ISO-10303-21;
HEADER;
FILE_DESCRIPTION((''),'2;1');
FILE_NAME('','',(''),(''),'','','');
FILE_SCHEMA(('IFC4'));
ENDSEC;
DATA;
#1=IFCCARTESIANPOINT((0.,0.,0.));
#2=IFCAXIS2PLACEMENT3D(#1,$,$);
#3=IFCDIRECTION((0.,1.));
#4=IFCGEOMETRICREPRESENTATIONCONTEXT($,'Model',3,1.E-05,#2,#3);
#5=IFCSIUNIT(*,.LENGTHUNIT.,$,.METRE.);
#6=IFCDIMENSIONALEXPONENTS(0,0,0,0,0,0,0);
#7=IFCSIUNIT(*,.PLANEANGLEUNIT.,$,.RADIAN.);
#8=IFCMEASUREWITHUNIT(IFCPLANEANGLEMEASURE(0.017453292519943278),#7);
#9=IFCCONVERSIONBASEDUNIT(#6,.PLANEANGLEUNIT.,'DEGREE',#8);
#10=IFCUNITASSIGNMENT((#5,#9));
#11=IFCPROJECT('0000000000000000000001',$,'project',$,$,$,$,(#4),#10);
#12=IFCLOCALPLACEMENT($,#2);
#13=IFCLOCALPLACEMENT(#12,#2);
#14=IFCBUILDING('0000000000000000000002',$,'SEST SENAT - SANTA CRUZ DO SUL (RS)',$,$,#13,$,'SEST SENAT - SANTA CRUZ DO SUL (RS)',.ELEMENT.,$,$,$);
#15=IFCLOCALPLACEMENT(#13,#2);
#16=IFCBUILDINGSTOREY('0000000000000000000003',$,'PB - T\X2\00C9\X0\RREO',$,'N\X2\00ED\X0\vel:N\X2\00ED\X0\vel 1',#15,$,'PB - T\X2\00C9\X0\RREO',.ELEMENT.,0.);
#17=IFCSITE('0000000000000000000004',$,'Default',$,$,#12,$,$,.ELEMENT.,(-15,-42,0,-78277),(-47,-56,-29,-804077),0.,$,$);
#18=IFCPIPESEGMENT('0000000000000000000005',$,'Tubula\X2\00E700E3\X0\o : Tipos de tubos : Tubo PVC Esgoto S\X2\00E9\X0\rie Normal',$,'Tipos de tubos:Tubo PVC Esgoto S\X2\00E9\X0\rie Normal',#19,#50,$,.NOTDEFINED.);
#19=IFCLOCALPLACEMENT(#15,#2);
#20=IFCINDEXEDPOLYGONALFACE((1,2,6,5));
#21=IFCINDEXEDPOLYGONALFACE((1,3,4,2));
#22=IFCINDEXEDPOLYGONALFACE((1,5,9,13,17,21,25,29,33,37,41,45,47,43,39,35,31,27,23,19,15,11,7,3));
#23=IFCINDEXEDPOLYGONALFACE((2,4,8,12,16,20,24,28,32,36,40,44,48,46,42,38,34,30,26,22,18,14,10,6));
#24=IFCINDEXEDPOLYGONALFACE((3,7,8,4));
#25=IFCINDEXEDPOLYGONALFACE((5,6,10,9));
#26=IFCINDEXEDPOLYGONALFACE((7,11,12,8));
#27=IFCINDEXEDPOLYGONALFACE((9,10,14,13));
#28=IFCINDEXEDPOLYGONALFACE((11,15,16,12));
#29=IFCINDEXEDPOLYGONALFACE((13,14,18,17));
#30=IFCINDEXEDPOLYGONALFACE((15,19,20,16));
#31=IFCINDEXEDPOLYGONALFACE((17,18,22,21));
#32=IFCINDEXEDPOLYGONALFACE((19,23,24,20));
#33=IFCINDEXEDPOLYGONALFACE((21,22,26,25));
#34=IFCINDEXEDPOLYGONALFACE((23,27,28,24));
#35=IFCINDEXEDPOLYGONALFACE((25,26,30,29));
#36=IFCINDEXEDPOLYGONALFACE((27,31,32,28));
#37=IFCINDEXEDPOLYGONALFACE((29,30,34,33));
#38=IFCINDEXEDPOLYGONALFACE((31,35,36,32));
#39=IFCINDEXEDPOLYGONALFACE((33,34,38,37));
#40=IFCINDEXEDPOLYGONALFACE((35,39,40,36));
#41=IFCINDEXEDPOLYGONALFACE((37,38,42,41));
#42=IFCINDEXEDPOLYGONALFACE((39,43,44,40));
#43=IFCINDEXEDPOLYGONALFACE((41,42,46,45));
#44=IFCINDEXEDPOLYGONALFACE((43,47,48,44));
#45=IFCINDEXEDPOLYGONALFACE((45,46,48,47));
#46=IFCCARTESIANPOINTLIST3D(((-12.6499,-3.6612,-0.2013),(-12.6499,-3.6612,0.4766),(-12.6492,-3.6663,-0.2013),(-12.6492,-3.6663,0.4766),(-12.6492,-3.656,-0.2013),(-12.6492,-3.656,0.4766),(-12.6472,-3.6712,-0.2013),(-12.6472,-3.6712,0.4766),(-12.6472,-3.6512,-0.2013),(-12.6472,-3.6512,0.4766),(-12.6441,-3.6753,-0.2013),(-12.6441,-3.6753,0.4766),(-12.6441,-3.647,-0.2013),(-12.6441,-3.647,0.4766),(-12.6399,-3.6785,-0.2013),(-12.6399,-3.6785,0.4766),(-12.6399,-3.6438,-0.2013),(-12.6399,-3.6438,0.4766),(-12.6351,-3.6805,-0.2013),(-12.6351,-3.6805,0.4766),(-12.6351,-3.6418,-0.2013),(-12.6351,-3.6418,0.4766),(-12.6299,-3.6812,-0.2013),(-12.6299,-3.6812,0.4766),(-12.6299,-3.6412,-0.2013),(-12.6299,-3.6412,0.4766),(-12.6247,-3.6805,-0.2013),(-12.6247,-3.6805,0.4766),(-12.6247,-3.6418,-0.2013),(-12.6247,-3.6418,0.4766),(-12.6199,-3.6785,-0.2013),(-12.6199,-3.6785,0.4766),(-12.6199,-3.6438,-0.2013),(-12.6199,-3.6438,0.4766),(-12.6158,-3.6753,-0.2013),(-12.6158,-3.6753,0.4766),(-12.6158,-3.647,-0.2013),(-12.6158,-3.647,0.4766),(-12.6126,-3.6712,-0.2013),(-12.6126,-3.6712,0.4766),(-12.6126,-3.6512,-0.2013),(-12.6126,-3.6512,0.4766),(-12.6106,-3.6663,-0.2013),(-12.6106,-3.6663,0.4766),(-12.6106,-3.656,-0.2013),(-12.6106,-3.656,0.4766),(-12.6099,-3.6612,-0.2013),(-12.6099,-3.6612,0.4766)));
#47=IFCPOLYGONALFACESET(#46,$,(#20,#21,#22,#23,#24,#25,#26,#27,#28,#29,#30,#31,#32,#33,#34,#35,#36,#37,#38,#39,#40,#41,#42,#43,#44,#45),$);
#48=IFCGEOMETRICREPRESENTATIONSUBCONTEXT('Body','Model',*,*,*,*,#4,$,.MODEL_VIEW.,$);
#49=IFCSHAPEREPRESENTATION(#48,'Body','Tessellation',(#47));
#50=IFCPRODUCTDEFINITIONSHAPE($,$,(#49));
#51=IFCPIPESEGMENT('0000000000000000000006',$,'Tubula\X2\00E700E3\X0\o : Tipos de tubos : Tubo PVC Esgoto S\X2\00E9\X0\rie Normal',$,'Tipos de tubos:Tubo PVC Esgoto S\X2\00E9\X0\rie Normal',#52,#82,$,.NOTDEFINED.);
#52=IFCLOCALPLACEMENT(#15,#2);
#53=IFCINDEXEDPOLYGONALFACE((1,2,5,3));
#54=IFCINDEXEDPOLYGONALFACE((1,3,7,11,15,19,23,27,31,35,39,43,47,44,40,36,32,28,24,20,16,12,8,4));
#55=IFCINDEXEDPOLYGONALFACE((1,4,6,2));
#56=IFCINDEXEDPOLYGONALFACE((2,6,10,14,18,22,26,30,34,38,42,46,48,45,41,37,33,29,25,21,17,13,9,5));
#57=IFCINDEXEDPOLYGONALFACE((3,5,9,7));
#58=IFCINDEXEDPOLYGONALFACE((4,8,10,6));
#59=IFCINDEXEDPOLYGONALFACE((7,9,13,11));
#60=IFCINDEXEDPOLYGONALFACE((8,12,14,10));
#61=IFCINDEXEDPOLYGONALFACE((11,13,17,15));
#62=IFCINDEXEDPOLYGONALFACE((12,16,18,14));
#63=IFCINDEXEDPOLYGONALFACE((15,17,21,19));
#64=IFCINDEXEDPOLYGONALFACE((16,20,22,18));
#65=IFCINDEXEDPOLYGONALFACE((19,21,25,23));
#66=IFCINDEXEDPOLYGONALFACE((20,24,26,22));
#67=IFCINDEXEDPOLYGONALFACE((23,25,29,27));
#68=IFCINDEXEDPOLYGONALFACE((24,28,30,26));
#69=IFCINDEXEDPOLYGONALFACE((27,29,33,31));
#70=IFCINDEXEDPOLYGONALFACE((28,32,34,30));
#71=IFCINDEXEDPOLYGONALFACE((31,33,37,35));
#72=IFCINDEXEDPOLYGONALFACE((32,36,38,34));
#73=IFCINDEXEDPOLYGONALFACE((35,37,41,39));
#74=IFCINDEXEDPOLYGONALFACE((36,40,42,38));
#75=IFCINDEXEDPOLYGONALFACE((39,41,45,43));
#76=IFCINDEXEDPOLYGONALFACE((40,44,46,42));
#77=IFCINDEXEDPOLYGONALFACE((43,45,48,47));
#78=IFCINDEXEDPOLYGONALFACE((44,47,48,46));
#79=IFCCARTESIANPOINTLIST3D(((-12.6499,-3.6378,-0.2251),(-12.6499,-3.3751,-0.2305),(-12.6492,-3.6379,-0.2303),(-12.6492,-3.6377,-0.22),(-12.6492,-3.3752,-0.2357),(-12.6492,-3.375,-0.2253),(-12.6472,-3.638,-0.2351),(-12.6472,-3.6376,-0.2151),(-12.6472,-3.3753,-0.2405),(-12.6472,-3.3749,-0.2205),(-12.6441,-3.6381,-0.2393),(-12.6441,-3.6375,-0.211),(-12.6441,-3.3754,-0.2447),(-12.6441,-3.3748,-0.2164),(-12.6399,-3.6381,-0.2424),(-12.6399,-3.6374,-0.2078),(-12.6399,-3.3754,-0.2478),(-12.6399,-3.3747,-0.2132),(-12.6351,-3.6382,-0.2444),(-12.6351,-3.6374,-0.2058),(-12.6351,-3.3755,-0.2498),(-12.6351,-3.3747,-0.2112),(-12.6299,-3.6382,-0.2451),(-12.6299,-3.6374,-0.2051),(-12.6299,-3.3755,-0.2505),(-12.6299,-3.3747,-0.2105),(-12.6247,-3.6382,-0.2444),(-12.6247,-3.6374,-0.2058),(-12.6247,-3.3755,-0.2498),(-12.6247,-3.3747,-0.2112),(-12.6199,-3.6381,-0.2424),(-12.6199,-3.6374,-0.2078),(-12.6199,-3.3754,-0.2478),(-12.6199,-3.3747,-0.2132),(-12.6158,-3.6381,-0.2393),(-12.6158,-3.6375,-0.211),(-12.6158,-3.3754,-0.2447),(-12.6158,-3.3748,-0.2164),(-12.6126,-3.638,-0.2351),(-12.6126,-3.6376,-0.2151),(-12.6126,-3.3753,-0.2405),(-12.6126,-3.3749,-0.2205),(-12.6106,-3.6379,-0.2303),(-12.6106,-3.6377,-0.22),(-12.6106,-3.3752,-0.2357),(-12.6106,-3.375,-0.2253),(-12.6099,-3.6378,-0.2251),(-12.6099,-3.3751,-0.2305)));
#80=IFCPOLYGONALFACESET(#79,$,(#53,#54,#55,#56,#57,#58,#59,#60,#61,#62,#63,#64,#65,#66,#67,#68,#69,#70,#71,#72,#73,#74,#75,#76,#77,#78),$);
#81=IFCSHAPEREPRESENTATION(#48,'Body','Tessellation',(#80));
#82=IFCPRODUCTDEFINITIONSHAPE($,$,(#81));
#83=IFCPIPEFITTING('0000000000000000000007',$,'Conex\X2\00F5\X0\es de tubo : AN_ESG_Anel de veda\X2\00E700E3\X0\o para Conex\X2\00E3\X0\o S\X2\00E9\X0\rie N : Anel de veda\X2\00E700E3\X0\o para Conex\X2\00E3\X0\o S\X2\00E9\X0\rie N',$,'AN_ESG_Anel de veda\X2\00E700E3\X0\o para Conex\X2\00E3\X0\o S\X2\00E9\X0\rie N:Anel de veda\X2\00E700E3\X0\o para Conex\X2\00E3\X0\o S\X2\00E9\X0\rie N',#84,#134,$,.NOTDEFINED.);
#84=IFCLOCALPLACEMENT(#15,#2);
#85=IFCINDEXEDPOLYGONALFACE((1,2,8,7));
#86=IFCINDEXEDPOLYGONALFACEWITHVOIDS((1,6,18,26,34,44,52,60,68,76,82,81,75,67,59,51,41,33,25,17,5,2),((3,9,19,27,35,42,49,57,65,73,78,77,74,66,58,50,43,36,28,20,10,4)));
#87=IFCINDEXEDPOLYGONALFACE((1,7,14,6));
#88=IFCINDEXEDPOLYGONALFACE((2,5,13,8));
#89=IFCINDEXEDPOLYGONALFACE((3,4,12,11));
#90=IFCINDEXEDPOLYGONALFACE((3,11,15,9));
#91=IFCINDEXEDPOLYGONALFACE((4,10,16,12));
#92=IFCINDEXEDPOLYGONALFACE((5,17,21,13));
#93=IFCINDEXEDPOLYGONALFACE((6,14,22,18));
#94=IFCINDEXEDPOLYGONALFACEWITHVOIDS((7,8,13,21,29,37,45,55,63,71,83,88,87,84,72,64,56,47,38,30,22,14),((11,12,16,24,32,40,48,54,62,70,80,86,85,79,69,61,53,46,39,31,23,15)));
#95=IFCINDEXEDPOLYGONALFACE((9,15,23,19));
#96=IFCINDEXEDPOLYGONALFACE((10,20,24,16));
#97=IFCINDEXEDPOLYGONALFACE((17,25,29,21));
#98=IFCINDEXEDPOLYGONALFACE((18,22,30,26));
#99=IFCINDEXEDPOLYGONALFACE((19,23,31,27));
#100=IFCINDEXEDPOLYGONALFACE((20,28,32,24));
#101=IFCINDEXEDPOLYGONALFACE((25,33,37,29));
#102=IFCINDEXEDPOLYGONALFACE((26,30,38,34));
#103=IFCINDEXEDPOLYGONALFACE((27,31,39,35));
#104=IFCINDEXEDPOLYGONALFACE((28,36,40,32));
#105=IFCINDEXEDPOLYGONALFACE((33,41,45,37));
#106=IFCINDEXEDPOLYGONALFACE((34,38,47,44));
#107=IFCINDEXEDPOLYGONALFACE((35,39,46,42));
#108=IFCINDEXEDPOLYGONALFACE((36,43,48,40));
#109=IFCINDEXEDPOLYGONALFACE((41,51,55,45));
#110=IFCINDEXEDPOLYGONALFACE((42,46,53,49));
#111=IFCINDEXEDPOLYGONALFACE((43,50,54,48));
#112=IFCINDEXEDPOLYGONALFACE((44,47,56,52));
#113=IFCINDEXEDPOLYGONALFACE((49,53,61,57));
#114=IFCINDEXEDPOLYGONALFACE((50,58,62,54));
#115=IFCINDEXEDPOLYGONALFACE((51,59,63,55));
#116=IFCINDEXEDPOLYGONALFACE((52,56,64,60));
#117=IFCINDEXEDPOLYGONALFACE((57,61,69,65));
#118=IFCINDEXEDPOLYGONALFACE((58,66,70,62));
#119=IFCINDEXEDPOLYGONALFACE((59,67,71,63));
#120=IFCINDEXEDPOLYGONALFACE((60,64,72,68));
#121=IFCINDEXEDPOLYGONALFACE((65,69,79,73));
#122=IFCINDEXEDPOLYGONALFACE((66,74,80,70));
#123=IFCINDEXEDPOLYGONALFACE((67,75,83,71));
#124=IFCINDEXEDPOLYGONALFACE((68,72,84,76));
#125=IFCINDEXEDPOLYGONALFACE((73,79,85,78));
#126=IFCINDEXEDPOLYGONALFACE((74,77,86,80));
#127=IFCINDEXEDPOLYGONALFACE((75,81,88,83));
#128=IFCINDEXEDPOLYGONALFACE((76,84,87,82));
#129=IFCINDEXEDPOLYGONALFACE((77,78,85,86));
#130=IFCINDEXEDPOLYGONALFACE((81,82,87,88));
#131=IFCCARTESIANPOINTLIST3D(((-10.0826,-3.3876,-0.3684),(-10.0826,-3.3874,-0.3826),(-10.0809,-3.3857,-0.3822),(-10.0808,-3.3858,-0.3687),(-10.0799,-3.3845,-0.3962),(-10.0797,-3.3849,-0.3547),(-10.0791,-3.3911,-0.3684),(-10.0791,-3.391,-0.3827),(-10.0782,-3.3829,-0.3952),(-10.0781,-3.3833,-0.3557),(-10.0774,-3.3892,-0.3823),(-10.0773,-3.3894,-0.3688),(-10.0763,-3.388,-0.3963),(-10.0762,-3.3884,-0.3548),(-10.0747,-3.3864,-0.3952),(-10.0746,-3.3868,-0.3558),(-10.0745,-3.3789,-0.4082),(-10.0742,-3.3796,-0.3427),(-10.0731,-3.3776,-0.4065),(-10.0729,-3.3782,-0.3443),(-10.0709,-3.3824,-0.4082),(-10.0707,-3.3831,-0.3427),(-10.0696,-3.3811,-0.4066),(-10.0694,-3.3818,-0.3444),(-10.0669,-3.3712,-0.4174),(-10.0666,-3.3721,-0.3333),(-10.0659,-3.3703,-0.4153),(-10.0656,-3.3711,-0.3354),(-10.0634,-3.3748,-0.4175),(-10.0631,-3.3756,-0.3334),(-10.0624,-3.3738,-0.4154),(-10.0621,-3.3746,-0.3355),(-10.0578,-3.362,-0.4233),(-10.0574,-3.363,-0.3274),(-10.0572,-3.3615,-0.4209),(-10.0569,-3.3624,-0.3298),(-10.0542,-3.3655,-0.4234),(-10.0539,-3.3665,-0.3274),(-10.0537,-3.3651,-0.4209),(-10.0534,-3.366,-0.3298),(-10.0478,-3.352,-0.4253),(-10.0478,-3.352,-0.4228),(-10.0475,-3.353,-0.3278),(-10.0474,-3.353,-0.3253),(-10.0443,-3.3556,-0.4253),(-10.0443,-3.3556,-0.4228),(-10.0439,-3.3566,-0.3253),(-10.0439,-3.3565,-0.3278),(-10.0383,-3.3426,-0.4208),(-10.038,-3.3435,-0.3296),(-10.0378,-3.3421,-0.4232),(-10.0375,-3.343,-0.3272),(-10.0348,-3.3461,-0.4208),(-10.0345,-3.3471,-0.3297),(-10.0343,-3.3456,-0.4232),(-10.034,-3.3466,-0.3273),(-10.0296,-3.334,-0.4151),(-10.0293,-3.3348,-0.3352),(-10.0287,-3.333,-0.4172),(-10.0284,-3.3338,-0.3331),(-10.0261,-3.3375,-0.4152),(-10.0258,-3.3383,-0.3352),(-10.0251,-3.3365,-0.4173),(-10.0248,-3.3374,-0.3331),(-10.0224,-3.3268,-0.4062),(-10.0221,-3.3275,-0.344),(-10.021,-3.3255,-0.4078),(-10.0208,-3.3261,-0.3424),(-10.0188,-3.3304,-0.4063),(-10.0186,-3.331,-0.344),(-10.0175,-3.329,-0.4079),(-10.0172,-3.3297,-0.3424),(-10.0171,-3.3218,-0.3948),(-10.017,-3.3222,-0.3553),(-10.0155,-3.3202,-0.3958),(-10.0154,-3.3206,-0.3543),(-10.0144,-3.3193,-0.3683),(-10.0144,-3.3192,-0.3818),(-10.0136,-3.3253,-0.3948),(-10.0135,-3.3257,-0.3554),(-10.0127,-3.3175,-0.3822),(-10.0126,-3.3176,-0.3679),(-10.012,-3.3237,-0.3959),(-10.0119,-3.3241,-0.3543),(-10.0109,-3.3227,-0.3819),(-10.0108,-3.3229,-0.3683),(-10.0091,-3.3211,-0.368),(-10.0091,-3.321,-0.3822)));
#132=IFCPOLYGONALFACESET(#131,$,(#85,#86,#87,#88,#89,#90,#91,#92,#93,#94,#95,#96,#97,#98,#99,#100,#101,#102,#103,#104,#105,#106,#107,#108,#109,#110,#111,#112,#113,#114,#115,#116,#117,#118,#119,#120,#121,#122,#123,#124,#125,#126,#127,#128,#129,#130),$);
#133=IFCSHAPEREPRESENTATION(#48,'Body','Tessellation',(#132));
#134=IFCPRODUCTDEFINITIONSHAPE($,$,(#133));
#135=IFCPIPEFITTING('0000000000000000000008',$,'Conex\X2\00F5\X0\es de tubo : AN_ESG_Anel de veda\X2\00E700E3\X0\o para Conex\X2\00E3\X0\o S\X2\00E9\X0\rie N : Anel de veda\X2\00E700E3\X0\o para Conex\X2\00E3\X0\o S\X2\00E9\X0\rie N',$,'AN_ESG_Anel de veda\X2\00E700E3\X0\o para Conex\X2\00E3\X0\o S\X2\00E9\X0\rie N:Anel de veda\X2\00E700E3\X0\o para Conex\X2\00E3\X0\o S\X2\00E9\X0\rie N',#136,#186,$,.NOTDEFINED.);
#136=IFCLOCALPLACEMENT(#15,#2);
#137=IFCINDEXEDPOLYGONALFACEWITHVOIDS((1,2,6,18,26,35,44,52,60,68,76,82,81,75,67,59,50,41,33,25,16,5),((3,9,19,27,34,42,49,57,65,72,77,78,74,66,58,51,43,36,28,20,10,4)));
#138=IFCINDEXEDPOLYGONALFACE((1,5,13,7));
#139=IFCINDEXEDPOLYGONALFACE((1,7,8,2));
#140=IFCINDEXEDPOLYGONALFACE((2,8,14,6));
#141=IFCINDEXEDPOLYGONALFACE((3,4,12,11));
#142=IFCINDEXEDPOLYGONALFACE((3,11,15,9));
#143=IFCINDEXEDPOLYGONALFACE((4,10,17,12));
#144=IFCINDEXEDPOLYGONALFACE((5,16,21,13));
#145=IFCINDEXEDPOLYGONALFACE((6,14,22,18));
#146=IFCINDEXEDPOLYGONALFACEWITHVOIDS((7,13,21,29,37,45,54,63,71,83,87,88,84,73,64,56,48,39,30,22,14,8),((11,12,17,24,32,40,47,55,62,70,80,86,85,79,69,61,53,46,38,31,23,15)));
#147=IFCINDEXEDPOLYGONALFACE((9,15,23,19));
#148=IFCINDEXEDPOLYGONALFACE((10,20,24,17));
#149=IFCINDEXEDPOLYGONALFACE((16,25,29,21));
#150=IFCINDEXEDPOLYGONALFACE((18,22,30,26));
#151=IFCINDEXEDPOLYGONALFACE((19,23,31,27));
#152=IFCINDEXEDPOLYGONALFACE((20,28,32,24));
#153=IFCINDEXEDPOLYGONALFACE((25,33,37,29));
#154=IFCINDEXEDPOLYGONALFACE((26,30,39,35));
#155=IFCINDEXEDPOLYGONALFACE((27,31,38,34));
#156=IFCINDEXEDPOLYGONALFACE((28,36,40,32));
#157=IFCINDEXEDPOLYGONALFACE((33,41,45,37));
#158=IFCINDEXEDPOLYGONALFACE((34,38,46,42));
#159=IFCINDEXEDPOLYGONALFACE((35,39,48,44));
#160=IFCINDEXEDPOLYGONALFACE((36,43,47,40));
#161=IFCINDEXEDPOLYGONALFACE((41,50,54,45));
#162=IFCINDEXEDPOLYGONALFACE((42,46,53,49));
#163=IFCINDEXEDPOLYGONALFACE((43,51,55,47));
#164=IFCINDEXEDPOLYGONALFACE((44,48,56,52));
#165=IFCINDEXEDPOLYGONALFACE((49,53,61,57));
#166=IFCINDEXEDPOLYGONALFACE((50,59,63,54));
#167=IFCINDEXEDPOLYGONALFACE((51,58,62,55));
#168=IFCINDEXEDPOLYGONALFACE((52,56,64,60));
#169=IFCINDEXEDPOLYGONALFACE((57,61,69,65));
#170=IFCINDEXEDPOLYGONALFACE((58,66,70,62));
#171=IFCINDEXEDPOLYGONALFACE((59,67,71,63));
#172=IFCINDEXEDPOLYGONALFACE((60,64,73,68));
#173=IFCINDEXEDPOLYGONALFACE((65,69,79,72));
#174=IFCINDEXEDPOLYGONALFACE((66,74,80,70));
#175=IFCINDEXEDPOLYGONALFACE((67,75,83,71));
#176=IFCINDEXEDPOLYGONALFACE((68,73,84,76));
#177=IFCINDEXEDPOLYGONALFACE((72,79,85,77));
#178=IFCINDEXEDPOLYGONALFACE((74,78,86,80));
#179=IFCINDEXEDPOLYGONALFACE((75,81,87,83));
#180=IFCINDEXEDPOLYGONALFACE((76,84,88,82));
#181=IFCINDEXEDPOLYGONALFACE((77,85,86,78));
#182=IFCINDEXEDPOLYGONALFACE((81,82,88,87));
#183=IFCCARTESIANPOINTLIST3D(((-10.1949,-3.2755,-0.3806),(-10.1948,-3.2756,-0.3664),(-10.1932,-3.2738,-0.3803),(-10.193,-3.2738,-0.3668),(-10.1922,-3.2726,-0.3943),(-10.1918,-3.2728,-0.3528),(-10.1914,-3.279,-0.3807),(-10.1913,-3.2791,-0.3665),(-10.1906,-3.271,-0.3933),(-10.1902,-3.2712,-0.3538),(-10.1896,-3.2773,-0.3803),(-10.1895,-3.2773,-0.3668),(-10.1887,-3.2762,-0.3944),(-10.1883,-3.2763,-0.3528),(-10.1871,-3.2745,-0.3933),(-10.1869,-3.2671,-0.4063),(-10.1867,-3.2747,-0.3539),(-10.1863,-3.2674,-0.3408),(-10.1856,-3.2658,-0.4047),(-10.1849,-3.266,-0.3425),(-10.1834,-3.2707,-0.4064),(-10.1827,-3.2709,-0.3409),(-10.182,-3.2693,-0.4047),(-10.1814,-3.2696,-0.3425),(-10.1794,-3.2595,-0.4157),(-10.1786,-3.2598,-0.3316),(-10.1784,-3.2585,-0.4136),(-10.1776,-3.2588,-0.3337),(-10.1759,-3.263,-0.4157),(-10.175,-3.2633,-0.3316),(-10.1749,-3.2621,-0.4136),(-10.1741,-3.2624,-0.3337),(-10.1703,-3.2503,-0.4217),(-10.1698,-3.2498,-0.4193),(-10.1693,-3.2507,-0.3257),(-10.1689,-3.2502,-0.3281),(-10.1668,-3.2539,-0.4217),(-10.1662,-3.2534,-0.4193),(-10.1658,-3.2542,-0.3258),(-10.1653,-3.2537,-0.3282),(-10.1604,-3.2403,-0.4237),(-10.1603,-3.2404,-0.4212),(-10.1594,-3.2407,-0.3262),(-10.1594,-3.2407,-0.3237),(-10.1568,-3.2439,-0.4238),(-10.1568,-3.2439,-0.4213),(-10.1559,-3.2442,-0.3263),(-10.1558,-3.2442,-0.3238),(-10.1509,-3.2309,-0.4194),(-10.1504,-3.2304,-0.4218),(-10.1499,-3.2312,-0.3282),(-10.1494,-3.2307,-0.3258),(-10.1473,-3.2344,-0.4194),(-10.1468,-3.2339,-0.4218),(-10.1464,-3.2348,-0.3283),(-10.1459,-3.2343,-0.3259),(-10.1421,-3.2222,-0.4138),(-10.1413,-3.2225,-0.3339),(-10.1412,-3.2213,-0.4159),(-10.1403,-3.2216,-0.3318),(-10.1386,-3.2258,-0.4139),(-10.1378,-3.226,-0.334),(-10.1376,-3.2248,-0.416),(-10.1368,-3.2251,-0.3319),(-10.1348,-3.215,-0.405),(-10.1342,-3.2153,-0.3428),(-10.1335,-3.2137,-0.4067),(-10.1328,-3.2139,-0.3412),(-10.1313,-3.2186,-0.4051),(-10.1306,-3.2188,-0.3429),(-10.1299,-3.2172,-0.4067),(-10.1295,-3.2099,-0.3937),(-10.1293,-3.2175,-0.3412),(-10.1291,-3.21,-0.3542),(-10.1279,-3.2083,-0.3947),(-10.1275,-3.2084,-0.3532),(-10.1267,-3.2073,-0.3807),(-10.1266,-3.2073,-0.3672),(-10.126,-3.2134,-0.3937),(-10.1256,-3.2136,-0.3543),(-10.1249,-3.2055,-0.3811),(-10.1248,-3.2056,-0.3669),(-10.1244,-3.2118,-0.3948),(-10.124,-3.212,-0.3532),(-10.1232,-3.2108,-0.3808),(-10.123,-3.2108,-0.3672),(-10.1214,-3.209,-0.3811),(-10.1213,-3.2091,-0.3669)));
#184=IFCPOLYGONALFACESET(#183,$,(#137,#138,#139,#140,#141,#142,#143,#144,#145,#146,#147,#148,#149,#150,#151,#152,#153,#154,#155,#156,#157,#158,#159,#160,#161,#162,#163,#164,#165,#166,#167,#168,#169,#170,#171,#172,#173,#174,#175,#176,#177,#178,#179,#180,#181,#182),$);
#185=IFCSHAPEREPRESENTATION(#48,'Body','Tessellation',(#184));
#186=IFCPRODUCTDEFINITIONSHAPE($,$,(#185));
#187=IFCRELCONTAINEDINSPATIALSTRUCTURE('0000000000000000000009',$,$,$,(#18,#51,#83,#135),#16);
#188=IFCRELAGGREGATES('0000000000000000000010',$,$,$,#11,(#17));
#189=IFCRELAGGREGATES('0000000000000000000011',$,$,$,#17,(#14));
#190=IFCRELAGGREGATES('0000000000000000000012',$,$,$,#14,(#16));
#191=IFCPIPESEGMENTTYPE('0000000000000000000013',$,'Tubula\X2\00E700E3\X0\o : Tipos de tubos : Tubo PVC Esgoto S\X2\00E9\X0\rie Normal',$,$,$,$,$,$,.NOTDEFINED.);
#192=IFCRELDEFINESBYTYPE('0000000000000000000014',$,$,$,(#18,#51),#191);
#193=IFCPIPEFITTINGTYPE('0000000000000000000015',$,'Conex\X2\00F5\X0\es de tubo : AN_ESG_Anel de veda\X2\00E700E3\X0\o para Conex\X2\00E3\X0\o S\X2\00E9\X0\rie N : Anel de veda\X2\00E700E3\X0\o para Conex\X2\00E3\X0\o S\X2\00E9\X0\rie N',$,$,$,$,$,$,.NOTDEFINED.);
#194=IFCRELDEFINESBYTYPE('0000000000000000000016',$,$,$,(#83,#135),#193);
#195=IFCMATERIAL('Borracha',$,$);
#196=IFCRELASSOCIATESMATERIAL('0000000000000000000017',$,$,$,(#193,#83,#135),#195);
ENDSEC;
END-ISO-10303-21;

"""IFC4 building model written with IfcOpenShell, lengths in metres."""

from ifc_helpers import new_model, entity, si_unit, converted_unit, direction, frame, origin, place, context, subcontext, project, spatial, arc, indexed_curve, outline, extrude, source, transform, mapped, material, type_object, type_shapes, element, save


model = new_model("IFC4")

# Units and contexts
model_context = context("Model", 3, precision=1e-05, world=origin(), true_north=direction((0.0, 1.0)))
body_context = subcontext(model_context, "Body", "Model", "MODEL_VIEW")
ifc_project = project(units=[si_unit("LENGTHUNIT", "METRE"), converted_unit("PLANEANGLEUNIT", "DEGREE", entity("IfcPlaneAngleMeasure", 0.017453292519943278), si_unit("PLANEANGLEUNIT", "RADIAN"), dimensions=[0, 0, 0, 0, 0, 0, 0])], contexts=[model_context])

# Site, building, storey
site_placement = place(None, origin())
site = spatial("IfcSite", under=ifc_project, at=site_placement, Name="Default", CompositionType="ELEMENT", RefLatitude=(-15, -42, 0, -78277), RefLongitude=(-47, -56, -29, -804077), RefElevation=0.0)
building_placement = place(site_placement, origin())
building = spatial("IfcBuilding", under=site, at=building_placement, Name="SEST SENAT - SANTA CRUZ DO SUL (RS)", LongName="SEST SENAT - SANTA CRUZ DO SUL (RS)", CompositionType="ELEMENT")
storey_placement = place(building_placement, origin())
storey = spatial("IfcBuildingStorey", under=building, at=storey_placement, Name="PB - TÉRREO", ObjectType="Nível:Nível 1", LongName="PB - TÉRREO", CompositionType="ELEMENT", Elevation=0.0)

# Pipe segments
pipe_segment_type_1 = type_object("IfcPipeSegmentType", Name="Tubulação : Tipos de tubos : Tubo PVC Esgoto Série Normal", PredefinedType="NOTDEFINED")
pipe_segment_1_placement = place(storey_placement, frame((-12.6515, -3.6828, -0.2013)))
element("IfcPipeSegment", 1, at=pipe_segment_1_placement, inside=storey, type_object=pipe_segment_type_1, Name="Tubulação : Tipos de tubos : Tubo PVC Esgoto Série Normal", ObjectType="Tipos de tubos:Tubo PVC Esgoto Série Normal", PredefinedType="NOTDEFINED", context=body_context, shape_type="SweptSolid", body=[
    extrude(outline(indexed_curve([(0.02, 0.0), (0.0141, 0.0141), (0.0, 0.02), (-0.0141, 0.0141), (-0.02, 0.0), (-0.0141, -0.0141), (0.0, -0.02), (0.0141, -0.0141)], segments=[arc(1, 2, 3), arc(3, 4, 5), arc(5, 6, 7), arc(7, 8, 1)], self_intersect=False)), frame((0.0216, 0.0216, 0.0)), (0.0, 0.0, 1.0), 0.6779),
])
pipe_segment_2_placement = place(storey_placement, frame((-12.6515, -3.6398, -0.2035)))
element("IfcPipeSegment", 2, at=pipe_segment_2_placement, inside=storey, type_object=pipe_segment_type_1, Name="Tubulação : Tipos de tubos : Tubo PVC Esgoto Série Normal", ObjectType="Tipos de tubos:Tubo PVC Esgoto Série Normal", PredefinedType="NOTDEFINED", context=body_context, shape_type="SweptSolid", body=[
    extrude(outline(indexed_curve([(0.02, 0.0), (0.0141, 0.0141), (0.0, 0.02), (-0.0141, 0.0141), (-0.02, 0.0), (-0.0141, -0.0141), (0.0, -0.02), (0.0141, -0.0141)], segments=[arc(1, 2, 3), arc(3, 4, 5), arc(5, 6, 7), arc(7, 8, 1)], self_intersect=False)), frame((0.0216, 0.2647, -0.027), z_axis=(0.0, -0.999789, 0.02052), x_axis=(1.0, 0.0, 0.0)), (0.0, 0.0, 1.0), 0.2628),
])

# Pipe fittings
ifc_material = material(Name="Borracha")
pipe_fitting_type_1 = type_object("IfcPipeFittingType", Name="Conexões de tubo : AN_ESG_Anel de vedação para Conexão Série N : Anel de vedação para Conexão Série N", PredefinedType="NOTDEFINED", material=ifc_material)
shared_shape_1 = source(origin(), body_context, "Body", "SweptSolid", [
    extrude(outline(indexed_curve([(-0.05, 0.0), (0.0, -0.05), (0.05, 0.0), (0.0, 0.05)], segments=[arc(1, 2, 3), arc(3, 4, 1)], self_intersect=False), holes=[indexed_curve([(-0.0475, 0.0), (0.0, 0.0475), (0.0475, 0.0), (0.0, -0.0475)], segments=[arc(1, 2, 3), arc(3, 4, 1)], self_intersect=False)]), frame((0.0, 0.0, -0.005)), (0.0, 0.0, 1.0), 0.005),
])
type_shapes(pipe_fitting_type_1, [shared_shape_1])
for number, where, z_axis, x_axis, name in (
    (3, (-10.0441, -3.3561, -0.3753), (0.707074, -0.707074, -0.009613), (0.003595, -0.009999, 0.999944), "Conexões de tubo : AN_ESG_Anel de vedação para Conexão Série N : Anel de vedação para Conexão Série N"),
    (4, (-10.1563, -3.2441, -0.3738), (0.707074, -0.707074, -0.009613), (0.009999, -0.003595, 0.999944), "Conexões de tubo : AN_ESG_Anel de vedação para Conexão Série N : Anel de vedação para Conexão Série N"),
):
    element("IfcPipeFitting", number, at=place(storey_placement, frame(where, z_axis=z_axis, x_axis=x_axis)), inside=storey, type_object=pipe_fitting_type_1, material=ifc_material, Name=name, ObjectType="AN_ESG_Anel de vedação para Conexão Série N:Anel de vedação para Conexão Série N", PredefinedType="NOTDEFINED", context=body_context, shape_type="MappedRepresentation", body=[
        mapped(shared_shape_1, transform((0.0, 0.0, 0.0), scale=1.0)),
    ])

save(model, "model.ifc")
